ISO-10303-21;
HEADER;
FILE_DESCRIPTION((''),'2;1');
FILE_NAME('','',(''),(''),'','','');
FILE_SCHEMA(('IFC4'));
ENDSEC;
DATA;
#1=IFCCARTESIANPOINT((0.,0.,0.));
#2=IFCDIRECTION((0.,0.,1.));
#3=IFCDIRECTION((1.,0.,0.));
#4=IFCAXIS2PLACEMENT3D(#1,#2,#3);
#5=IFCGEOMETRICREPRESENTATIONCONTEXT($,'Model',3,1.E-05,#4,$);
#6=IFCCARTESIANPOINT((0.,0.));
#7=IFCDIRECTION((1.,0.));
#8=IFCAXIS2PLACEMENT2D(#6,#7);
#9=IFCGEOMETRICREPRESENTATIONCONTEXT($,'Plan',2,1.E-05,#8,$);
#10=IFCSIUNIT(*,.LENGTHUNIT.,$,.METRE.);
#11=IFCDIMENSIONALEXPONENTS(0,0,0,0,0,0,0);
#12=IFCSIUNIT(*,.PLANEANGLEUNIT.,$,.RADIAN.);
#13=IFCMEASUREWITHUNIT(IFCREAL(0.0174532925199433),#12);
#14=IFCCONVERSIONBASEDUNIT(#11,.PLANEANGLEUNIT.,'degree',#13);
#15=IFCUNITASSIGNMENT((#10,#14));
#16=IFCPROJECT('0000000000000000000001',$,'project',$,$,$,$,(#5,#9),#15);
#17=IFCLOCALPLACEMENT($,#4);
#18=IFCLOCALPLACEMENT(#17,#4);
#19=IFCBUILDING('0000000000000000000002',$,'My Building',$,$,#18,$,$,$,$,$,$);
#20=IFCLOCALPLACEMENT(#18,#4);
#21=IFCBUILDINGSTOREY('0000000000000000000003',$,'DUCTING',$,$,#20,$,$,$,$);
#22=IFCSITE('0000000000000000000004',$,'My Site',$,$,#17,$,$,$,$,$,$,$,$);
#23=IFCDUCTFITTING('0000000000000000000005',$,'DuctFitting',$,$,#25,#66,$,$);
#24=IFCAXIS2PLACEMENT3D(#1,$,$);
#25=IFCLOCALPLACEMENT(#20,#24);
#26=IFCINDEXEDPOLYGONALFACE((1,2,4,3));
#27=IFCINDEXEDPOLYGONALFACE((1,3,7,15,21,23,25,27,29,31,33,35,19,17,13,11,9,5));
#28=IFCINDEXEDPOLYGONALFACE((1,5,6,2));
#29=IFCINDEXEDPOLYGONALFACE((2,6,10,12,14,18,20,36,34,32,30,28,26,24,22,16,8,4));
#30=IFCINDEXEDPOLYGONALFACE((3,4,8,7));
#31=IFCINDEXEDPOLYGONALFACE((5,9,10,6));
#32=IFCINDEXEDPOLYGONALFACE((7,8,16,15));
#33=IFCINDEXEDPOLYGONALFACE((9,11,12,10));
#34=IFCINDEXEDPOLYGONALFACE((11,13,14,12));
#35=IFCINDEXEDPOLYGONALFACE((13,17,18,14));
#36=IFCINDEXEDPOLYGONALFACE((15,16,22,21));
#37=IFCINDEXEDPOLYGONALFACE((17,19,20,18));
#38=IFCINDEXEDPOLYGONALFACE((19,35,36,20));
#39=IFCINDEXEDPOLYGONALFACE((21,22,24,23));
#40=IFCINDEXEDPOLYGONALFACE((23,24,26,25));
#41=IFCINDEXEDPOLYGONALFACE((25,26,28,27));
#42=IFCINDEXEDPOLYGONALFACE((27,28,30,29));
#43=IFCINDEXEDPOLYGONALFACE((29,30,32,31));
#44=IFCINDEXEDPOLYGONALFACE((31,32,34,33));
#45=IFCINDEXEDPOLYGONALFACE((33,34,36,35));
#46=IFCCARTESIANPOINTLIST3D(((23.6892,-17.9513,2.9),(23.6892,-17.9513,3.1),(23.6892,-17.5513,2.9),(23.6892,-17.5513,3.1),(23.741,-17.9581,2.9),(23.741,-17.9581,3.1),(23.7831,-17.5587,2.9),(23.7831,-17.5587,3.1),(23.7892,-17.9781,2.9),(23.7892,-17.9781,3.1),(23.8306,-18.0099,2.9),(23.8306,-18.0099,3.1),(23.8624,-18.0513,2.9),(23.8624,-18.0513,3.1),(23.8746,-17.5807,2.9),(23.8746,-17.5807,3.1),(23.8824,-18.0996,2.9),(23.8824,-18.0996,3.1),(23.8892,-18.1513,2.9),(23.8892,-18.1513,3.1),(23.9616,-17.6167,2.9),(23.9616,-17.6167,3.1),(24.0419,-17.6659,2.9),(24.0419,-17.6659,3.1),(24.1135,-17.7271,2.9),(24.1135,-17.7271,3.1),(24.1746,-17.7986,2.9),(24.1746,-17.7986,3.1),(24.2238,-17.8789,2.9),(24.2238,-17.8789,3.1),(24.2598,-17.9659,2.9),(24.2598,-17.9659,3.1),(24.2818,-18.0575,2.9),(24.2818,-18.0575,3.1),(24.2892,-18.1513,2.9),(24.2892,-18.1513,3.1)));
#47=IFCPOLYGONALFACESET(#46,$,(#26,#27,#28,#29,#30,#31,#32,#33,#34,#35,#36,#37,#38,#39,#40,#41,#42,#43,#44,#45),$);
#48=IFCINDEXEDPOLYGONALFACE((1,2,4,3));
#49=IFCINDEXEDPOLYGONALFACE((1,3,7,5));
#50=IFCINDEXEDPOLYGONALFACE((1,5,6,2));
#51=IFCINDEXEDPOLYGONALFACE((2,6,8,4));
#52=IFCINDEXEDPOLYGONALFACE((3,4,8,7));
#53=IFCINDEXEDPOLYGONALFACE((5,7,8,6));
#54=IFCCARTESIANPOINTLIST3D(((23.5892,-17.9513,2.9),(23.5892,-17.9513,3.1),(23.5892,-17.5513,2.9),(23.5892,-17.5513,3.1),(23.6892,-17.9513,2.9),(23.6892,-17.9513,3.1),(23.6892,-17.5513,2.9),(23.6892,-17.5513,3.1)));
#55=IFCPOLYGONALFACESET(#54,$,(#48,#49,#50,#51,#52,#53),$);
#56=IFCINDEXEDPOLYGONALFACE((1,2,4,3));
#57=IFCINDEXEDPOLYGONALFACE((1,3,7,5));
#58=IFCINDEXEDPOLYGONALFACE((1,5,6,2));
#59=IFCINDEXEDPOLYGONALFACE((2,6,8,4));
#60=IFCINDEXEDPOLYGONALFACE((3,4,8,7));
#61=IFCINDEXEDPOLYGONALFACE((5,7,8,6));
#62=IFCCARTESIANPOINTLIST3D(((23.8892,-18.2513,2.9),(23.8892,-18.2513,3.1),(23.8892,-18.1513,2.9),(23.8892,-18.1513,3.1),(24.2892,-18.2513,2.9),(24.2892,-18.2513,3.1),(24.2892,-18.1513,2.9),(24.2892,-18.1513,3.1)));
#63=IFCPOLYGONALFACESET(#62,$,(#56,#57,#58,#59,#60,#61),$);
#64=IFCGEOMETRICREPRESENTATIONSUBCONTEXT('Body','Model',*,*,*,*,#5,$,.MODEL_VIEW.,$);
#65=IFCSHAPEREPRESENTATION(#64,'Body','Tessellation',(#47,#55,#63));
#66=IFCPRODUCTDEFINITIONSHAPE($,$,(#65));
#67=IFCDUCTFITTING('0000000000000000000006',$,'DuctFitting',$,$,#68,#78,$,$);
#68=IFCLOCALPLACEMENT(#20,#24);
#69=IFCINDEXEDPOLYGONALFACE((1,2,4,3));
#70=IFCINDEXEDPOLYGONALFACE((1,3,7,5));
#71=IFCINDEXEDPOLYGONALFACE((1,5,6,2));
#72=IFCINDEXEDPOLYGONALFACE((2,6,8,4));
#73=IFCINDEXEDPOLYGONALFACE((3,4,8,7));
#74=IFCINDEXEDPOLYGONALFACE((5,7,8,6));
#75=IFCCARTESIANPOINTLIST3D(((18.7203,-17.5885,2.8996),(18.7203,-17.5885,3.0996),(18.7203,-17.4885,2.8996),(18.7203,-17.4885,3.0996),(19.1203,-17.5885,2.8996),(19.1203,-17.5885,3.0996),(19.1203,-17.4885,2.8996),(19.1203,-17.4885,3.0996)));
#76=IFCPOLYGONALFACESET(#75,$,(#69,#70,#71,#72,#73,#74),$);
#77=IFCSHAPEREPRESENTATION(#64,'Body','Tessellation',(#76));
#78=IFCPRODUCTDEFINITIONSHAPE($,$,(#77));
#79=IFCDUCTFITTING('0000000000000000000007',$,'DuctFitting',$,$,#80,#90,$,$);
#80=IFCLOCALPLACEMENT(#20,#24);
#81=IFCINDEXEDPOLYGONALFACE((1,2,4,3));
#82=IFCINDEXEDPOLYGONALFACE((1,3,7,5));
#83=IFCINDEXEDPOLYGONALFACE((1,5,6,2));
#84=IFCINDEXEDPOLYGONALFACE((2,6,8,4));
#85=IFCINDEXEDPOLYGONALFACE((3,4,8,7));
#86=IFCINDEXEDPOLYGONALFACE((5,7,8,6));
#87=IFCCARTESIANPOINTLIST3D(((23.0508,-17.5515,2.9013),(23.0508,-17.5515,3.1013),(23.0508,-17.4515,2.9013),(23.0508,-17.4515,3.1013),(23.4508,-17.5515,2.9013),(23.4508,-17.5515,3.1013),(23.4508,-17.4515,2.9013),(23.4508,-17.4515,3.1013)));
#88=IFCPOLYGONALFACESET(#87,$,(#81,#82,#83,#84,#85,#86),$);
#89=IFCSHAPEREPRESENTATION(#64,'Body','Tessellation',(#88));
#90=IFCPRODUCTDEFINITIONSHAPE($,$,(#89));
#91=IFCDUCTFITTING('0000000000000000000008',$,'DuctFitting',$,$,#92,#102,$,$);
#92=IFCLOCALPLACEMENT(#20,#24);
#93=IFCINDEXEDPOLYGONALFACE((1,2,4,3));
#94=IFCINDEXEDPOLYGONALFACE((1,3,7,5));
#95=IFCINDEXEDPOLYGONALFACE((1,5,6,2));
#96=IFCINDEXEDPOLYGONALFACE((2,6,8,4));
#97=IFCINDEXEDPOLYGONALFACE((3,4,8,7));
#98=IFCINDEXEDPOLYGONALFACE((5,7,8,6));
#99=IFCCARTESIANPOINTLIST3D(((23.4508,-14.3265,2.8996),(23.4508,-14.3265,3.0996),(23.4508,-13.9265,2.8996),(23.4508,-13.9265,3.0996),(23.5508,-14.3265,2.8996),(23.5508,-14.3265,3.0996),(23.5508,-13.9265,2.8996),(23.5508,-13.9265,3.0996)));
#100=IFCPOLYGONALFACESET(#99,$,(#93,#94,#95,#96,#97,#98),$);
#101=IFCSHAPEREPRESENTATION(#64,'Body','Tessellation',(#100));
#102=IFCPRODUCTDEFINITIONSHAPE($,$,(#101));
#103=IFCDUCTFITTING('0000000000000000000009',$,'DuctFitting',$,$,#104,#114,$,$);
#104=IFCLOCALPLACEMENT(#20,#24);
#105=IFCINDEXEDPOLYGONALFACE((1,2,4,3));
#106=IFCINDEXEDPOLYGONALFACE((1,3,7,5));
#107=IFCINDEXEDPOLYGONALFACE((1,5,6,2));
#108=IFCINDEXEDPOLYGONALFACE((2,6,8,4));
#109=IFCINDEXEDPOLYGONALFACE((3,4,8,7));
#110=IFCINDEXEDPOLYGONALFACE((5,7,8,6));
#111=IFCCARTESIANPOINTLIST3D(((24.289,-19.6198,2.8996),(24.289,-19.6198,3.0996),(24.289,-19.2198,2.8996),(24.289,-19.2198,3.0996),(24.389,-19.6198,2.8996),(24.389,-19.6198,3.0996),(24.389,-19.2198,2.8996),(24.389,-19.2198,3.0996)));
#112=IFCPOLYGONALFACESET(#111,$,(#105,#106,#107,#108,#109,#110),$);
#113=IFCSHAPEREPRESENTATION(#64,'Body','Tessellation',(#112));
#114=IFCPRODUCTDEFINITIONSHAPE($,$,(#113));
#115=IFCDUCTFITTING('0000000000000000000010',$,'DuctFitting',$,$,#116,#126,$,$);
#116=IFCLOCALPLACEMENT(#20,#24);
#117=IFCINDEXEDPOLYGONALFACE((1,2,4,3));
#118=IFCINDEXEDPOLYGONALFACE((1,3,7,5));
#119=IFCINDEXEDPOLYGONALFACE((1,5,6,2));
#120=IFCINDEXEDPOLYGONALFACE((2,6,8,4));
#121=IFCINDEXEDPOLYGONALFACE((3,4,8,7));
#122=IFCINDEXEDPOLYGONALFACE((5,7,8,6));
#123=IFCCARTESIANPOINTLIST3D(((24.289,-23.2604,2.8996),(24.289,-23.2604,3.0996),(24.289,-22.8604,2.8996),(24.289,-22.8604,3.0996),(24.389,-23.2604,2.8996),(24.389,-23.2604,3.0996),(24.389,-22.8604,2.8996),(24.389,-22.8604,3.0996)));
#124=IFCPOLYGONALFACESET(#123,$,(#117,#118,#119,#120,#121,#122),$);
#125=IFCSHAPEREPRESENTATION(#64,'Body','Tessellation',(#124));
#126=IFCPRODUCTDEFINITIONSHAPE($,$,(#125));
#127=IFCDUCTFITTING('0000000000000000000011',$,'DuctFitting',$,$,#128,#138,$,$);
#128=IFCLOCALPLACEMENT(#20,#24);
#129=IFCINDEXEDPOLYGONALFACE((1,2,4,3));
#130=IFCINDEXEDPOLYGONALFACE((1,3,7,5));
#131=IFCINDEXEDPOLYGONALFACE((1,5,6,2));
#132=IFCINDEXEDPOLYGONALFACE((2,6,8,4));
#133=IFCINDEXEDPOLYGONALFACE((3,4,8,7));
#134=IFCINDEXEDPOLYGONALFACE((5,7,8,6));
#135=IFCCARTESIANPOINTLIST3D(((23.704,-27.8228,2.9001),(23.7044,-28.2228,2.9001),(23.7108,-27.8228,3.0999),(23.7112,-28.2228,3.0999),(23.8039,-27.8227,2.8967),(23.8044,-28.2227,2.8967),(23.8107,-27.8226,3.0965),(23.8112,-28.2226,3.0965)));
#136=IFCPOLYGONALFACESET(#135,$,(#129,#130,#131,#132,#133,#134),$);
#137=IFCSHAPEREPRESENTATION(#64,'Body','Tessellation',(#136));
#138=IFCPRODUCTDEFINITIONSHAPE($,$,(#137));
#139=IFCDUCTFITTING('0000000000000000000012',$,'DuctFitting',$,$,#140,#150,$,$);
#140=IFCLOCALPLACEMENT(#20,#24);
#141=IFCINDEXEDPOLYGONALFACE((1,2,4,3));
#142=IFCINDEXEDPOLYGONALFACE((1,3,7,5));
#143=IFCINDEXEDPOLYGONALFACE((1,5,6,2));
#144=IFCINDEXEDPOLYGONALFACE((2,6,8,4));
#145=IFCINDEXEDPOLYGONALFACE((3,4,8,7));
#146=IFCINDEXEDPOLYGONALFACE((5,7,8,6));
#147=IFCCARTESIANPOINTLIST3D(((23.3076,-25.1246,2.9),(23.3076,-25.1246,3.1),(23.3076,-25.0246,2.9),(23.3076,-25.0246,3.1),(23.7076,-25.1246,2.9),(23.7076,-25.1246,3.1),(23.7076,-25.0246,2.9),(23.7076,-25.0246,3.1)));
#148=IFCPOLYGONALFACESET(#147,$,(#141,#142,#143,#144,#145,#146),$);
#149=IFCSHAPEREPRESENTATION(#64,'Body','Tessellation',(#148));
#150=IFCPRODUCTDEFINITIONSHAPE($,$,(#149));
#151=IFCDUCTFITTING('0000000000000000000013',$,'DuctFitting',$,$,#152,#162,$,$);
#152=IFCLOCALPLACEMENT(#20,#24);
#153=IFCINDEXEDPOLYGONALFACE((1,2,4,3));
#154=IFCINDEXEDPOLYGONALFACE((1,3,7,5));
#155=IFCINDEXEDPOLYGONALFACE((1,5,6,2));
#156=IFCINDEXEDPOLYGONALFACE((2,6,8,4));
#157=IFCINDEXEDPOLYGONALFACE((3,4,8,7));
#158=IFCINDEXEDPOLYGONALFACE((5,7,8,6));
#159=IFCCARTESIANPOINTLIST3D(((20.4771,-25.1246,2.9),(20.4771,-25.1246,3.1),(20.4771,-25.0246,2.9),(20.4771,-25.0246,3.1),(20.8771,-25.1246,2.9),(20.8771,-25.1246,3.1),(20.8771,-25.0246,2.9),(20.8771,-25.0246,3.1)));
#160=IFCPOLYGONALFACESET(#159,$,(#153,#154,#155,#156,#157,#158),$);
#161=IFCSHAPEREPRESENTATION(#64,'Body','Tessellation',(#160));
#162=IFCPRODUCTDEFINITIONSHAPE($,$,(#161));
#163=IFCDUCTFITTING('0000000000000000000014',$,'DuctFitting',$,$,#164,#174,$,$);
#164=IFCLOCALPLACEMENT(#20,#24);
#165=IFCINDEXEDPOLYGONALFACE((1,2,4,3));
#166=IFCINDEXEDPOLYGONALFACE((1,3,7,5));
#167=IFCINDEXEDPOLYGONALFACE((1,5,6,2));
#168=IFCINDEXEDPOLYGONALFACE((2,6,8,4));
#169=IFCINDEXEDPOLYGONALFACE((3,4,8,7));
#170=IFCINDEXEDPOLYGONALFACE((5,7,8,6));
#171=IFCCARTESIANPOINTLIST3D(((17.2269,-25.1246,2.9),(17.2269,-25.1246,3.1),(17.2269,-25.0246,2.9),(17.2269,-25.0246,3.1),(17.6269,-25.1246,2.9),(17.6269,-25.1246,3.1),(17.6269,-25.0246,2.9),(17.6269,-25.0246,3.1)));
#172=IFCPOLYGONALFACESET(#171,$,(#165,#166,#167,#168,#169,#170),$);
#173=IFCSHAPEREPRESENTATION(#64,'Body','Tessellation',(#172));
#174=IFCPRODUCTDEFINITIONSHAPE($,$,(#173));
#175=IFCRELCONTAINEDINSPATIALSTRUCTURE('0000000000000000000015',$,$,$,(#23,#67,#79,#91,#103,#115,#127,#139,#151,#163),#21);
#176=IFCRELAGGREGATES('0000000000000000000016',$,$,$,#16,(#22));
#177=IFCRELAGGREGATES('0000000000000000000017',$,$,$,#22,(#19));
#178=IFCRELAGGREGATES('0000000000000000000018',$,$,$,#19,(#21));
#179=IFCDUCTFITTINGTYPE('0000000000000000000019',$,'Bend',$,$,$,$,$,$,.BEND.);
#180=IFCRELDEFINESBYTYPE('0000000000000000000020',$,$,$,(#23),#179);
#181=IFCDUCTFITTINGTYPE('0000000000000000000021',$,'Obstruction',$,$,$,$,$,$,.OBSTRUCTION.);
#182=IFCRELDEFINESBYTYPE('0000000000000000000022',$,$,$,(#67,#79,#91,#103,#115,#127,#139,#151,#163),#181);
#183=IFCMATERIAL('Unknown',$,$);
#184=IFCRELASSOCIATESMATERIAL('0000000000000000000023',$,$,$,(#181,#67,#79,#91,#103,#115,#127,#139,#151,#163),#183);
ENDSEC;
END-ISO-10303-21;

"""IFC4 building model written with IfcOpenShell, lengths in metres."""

from ifc_helpers import new_model, entity, si_unit, converted_unit, frame, origin_with_axes, origin_2d_with_axis, place, context, subcontext, project, spatial, line, arc, indexed_curve, rectangle, outline, extrude, source, transform, mapped, material, material_profile, profile_set, profile_usage, type_object, type_shapes, element, save


model = new_model("IFC4")

# Units and contexts
model_context = context("Model", 3, precision=1e-05, world=origin_with_axes())
plan_context = context("Plan", 2, precision=1e-05, world=origin_2d_with_axis())
body_context = subcontext(model_context, "Body", "Model", "MODEL_VIEW")
ifc_project = project(units=[si_unit("LENGTHUNIT", "METRE"), converted_unit("PLANEANGLEUNIT", "degree", entity("IfcReal", 0.0174532925199433), si_unit("PLANEANGLEUNIT", "RADIAN"), dimensions=[0, 0, 0, 0, 0, 0, 0])], contexts=[model_context, plan_context])

# Site, building, storey
site_placement = place(None, origin_with_axes())
site = spatial("IfcSite", under=ifc_project, at=site_placement, Name="My Site")
building_placement = place(site_placement, origin_with_axes())
building = spatial("IfcBuilding", under=site, at=building_placement, Name="My Building")
storey_placement = place(building_placement, origin_with_axes())
storey = spatial("IfcBuildingStorey", under=building, at=storey_placement, Name="DUCTING")

# Shared definitions
ifc_material = material(Name="Unknown")

# Duct fittings
duct_fitting_type_1 = type_object("IfcDuctFittingType", Name="Bend", PredefinedType="BEND")
shared_shape = source(origin_with_axes(), body_context, "Body", "SweptSolid", [
    extrude(outline(indexed_curve([(0.2, 0.0), (0.2586, -0.1414), (0.4, -0.2), (0.4, -0.6), (-0.0243, -0.4243), (-0.2, 0.0)], segments=[arc(1, 2, 3), line(3, 4), arc(4, 5, 6), line(6, 1)])), frame((0.0, -0.1, -0.1), z_axis=(0.0, -1.0, 0.0), x_axis=(1.0, 0.0, 0.0)), (0.0, 0.0, -1.0), 0.2),
    extrude(rectangle(XDim=0.4, YDim=0.2), origin_with_axes(), (0.0, 0.0, -1.0), 0.1),
    extrude(rectangle(XDim=0.4, YDim=0.2), frame((0.4, 0.0, -0.5), z_axis=(1.0, 0.0, 0.0), x_axis=(0.0, 0.0, 1.0)), (0.0, 0.0, 1.0), 0.1),
])
type_shapes(duct_fitting_type_1, [shared_shape])
for number, where, z_axis, x_axis, name in (
    (1, (23.5892, -17.7513, 3.0), (-1.0, 0.0, 0.0), (0.0, -1.0, 0.0), "DuctFitting"),
):
    element("IfcDuctFitting", number, at=place(storey_placement, frame(where, z_axis=z_axis, x_axis=x_axis)), inside=storey, type_object=duct_fitting_type_1, Name=name, context=body_context, shape_type="MappedRepresentation", body=[
        mapped(shared_shape, transform((0.0, 0.0, 0.0), x_axis=(1.0, 0.0, 0.0), y_axis=(0.0, 1.0, 0.0), z_axis=(0.0, 0.0, 1.0), scale=1.0)),
    ])
ifc_material_profile_1 = material_profile(ifc_material, rectangle(XDim=0.4, YDim=0.2))
ifc_profile_set_1 = profile_set([ifc_material_profile_1])
ifc_profile_usage_1 = profile_usage(ifc_profile_set_1, cardinal=5)
duct_fitting_type_2 = type_object("IfcDuctFittingType", Name="Obstruction", PredefinedType="OBSTRUCTION", material=ifc_profile_set_1)
duct_fitting_1_placement = place(storey_placement, frame((18.9203, -17.5885, 2.9996), z_axis=(0.0, 1.0, 0.0), x_axis=(-1.0, 0.0, 0.0)))
element("IfcDuctFitting", 2, at=duct_fitting_1_placement, inside=storey, type_object=duct_fitting_type_2, material=ifc_profile_usage_1, Name="DuctFitting", context=body_context, shape_type="SweptSolid", body=[
    extrude(rectangle(XDim=0.4, YDim=0.2), origin_with_axes(), (0.0, 0.0, 1.0), 0.1),
])
ifc_profile_usage_2 = profile_usage(ifc_profile_set_1, cardinal=5)
duct_fitting_2_placement = place(storey_placement, frame((23.2508, -17.5515, 3.0013), z_axis=(0.0, 1.0, 0.0), x_axis=(-1.0, 0.0, 0.0)))
element("IfcDuctFitting", 3, at=duct_fitting_2_placement, inside=storey, type_object=duct_fitting_type_2, material=ifc_profile_usage_2, Name="DuctFitting", context=body_context, shape_type="SweptSolid", body=[
    extrude(rectangle(XDim=0.4, YDim=0.2), origin_with_axes(), (0.0, 0.0, 1.0), 0.1),
])
ifc_profile_usage_3 = profile_usage(ifc_profile_set_1, cardinal=5)
duct_fitting_3_placement = place(storey_placement, frame((23.4508, -14.1265, 2.9996), z_axis=(1.0, 0.0, 0.0), x_axis=(0.0, 1.0, 0.0)))
element("IfcDuctFitting", 4, at=duct_fitting_3_placement, inside=storey, type_object=duct_fitting_type_2, material=ifc_profile_usage_3, Name="DuctFitting", context=body_context, shape_type="SweptSolid", body=[
    extrude(rectangle(XDim=0.4, YDim=0.2), origin_with_axes(), (0.0, 0.0, 1.0), 0.1),
])
ifc_profile_usage_4 = profile_usage(ifc_profile_set_1, cardinal=5)
duct_fitting_4_placement = place(storey_placement, frame((24.289, -19.4198, 2.9996), z_axis=(1.0, 0.0, 0.0), x_axis=(0.0, 1.0, 0.0)))
element("IfcDuctFitting", 5, at=duct_fitting_4_placement, inside=storey, type_object=duct_fitting_type_2, material=ifc_profile_usage_4, Name="DuctFitting", context=body_context, shape_type="SweptSolid", body=[
    extrude(rectangle(XDim=0.4, YDim=0.2), origin_with_axes(), (0.0, 0.0, 1.0), 0.1),
])
ifc_profile_usage_5 = profile_usage(ifc_profile_set_1, cardinal=5)
duct_fitting_5_placement = place(storey_placement, frame((24.289, -23.0604, 2.9996), z_axis=(1.0, 0.0, 0.0), x_axis=(0.0, 1.0, 0.0)))
element("IfcDuctFitting", 6, at=duct_fitting_5_placement, inside=storey, type_object=duct_fitting_type_2, material=ifc_profile_usage_5, Name="DuctFitting", context=body_context, shape_type="SweptSolid", body=[
    extrude(rectangle(XDim=0.4, YDim=0.2), origin_with_axes(), (0.0, 0.0, 1.0), 0.1),
])
ifc_profile_usage_6 = profile_usage(ifc_profile_set_1, cardinal=5)
duct_fitting_6_placement = place(storey_placement, frame((23.7076, -28.0228, 3.0), z_axis=(0.999418, 0.001135, -0.034093), x_axis=(-0.001136, 0.999999, 0.0)))
element("IfcDuctFitting", 7, at=duct_fitting_6_placement, inside=storey, type_object=duct_fitting_type_2, material=ifc_profile_usage_6, Name="DuctFitting", context=body_context, shape_type="SweptSolid", body=[
    extrude(rectangle(XDim=0.4, YDim=0.2), origin_with_axes(), (0.0, 0.0, 1.0), 0.1),
])
ifc_profile_usage_7 = profile_usage(ifc_profile_set_1, cardinal=5)
duct_fitting_7_placement = place(storey_placement, frame((23.5076, -25.0246, 3.0), z_axis=(0.0, -1.0, 0.0), x_axis=(1.0, 0.0, 0.0)))
element("IfcDuctFitting", 8, at=duct_fitting_7_placement, inside=storey, type_object=duct_fitting_type_2, material=ifc_profile_usage_7, Name="DuctFitting", context=body_context, shape_type="SweptSolid", body=[
    extrude(rectangle(XDim=0.4, YDim=0.2), origin_with_axes(), (0.0, 0.0, 1.0), 0.1),
])
ifc_profile_usage_8 = profile_usage(ifc_profile_set_1, cardinal=5)
duct_fitting_8_placement = place(storey_placement, frame((20.6771, -25.0246, 3.0), z_axis=(0.0, -1.0, 0.0), x_axis=(1.0, 0.0, 0.0)))
element("IfcDuctFitting", 9, at=duct_fitting_8_placement, inside=storey, type_object=duct_fitting_type_2, material=ifc_profile_usage_8, Name="DuctFitting", context=body_context, shape_type="SweptSolid", body=[
    extrude(rectangle(XDim=0.4, YDim=0.2), origin_with_axes(), (0.0, 0.0, 1.0), 0.1),
])
ifc_profile_usage_9 = profile_usage(ifc_profile_set_1, cardinal=5)
duct_fitting_9_placement = place(storey_placement, frame((17.4269, -25.0246, 3.0), z_axis=(0.0, -1.0, 0.0), x_axis=(1.0, 0.0, 0.0)))
element("IfcDuctFitting", 10, at=duct_fitting_9_placement, inside=storey, type_object=duct_fitting_type_2, material=ifc_profile_usage_9, Name="DuctFitting", context=body_context, shape_type="SweptSolid", body=[
    extrude(rectangle(XDim=0.4, YDim=0.2), origin_with_axes(), (0.0, 0.0, 1.0), 0.1),
])

save(model, "model.ifc")
